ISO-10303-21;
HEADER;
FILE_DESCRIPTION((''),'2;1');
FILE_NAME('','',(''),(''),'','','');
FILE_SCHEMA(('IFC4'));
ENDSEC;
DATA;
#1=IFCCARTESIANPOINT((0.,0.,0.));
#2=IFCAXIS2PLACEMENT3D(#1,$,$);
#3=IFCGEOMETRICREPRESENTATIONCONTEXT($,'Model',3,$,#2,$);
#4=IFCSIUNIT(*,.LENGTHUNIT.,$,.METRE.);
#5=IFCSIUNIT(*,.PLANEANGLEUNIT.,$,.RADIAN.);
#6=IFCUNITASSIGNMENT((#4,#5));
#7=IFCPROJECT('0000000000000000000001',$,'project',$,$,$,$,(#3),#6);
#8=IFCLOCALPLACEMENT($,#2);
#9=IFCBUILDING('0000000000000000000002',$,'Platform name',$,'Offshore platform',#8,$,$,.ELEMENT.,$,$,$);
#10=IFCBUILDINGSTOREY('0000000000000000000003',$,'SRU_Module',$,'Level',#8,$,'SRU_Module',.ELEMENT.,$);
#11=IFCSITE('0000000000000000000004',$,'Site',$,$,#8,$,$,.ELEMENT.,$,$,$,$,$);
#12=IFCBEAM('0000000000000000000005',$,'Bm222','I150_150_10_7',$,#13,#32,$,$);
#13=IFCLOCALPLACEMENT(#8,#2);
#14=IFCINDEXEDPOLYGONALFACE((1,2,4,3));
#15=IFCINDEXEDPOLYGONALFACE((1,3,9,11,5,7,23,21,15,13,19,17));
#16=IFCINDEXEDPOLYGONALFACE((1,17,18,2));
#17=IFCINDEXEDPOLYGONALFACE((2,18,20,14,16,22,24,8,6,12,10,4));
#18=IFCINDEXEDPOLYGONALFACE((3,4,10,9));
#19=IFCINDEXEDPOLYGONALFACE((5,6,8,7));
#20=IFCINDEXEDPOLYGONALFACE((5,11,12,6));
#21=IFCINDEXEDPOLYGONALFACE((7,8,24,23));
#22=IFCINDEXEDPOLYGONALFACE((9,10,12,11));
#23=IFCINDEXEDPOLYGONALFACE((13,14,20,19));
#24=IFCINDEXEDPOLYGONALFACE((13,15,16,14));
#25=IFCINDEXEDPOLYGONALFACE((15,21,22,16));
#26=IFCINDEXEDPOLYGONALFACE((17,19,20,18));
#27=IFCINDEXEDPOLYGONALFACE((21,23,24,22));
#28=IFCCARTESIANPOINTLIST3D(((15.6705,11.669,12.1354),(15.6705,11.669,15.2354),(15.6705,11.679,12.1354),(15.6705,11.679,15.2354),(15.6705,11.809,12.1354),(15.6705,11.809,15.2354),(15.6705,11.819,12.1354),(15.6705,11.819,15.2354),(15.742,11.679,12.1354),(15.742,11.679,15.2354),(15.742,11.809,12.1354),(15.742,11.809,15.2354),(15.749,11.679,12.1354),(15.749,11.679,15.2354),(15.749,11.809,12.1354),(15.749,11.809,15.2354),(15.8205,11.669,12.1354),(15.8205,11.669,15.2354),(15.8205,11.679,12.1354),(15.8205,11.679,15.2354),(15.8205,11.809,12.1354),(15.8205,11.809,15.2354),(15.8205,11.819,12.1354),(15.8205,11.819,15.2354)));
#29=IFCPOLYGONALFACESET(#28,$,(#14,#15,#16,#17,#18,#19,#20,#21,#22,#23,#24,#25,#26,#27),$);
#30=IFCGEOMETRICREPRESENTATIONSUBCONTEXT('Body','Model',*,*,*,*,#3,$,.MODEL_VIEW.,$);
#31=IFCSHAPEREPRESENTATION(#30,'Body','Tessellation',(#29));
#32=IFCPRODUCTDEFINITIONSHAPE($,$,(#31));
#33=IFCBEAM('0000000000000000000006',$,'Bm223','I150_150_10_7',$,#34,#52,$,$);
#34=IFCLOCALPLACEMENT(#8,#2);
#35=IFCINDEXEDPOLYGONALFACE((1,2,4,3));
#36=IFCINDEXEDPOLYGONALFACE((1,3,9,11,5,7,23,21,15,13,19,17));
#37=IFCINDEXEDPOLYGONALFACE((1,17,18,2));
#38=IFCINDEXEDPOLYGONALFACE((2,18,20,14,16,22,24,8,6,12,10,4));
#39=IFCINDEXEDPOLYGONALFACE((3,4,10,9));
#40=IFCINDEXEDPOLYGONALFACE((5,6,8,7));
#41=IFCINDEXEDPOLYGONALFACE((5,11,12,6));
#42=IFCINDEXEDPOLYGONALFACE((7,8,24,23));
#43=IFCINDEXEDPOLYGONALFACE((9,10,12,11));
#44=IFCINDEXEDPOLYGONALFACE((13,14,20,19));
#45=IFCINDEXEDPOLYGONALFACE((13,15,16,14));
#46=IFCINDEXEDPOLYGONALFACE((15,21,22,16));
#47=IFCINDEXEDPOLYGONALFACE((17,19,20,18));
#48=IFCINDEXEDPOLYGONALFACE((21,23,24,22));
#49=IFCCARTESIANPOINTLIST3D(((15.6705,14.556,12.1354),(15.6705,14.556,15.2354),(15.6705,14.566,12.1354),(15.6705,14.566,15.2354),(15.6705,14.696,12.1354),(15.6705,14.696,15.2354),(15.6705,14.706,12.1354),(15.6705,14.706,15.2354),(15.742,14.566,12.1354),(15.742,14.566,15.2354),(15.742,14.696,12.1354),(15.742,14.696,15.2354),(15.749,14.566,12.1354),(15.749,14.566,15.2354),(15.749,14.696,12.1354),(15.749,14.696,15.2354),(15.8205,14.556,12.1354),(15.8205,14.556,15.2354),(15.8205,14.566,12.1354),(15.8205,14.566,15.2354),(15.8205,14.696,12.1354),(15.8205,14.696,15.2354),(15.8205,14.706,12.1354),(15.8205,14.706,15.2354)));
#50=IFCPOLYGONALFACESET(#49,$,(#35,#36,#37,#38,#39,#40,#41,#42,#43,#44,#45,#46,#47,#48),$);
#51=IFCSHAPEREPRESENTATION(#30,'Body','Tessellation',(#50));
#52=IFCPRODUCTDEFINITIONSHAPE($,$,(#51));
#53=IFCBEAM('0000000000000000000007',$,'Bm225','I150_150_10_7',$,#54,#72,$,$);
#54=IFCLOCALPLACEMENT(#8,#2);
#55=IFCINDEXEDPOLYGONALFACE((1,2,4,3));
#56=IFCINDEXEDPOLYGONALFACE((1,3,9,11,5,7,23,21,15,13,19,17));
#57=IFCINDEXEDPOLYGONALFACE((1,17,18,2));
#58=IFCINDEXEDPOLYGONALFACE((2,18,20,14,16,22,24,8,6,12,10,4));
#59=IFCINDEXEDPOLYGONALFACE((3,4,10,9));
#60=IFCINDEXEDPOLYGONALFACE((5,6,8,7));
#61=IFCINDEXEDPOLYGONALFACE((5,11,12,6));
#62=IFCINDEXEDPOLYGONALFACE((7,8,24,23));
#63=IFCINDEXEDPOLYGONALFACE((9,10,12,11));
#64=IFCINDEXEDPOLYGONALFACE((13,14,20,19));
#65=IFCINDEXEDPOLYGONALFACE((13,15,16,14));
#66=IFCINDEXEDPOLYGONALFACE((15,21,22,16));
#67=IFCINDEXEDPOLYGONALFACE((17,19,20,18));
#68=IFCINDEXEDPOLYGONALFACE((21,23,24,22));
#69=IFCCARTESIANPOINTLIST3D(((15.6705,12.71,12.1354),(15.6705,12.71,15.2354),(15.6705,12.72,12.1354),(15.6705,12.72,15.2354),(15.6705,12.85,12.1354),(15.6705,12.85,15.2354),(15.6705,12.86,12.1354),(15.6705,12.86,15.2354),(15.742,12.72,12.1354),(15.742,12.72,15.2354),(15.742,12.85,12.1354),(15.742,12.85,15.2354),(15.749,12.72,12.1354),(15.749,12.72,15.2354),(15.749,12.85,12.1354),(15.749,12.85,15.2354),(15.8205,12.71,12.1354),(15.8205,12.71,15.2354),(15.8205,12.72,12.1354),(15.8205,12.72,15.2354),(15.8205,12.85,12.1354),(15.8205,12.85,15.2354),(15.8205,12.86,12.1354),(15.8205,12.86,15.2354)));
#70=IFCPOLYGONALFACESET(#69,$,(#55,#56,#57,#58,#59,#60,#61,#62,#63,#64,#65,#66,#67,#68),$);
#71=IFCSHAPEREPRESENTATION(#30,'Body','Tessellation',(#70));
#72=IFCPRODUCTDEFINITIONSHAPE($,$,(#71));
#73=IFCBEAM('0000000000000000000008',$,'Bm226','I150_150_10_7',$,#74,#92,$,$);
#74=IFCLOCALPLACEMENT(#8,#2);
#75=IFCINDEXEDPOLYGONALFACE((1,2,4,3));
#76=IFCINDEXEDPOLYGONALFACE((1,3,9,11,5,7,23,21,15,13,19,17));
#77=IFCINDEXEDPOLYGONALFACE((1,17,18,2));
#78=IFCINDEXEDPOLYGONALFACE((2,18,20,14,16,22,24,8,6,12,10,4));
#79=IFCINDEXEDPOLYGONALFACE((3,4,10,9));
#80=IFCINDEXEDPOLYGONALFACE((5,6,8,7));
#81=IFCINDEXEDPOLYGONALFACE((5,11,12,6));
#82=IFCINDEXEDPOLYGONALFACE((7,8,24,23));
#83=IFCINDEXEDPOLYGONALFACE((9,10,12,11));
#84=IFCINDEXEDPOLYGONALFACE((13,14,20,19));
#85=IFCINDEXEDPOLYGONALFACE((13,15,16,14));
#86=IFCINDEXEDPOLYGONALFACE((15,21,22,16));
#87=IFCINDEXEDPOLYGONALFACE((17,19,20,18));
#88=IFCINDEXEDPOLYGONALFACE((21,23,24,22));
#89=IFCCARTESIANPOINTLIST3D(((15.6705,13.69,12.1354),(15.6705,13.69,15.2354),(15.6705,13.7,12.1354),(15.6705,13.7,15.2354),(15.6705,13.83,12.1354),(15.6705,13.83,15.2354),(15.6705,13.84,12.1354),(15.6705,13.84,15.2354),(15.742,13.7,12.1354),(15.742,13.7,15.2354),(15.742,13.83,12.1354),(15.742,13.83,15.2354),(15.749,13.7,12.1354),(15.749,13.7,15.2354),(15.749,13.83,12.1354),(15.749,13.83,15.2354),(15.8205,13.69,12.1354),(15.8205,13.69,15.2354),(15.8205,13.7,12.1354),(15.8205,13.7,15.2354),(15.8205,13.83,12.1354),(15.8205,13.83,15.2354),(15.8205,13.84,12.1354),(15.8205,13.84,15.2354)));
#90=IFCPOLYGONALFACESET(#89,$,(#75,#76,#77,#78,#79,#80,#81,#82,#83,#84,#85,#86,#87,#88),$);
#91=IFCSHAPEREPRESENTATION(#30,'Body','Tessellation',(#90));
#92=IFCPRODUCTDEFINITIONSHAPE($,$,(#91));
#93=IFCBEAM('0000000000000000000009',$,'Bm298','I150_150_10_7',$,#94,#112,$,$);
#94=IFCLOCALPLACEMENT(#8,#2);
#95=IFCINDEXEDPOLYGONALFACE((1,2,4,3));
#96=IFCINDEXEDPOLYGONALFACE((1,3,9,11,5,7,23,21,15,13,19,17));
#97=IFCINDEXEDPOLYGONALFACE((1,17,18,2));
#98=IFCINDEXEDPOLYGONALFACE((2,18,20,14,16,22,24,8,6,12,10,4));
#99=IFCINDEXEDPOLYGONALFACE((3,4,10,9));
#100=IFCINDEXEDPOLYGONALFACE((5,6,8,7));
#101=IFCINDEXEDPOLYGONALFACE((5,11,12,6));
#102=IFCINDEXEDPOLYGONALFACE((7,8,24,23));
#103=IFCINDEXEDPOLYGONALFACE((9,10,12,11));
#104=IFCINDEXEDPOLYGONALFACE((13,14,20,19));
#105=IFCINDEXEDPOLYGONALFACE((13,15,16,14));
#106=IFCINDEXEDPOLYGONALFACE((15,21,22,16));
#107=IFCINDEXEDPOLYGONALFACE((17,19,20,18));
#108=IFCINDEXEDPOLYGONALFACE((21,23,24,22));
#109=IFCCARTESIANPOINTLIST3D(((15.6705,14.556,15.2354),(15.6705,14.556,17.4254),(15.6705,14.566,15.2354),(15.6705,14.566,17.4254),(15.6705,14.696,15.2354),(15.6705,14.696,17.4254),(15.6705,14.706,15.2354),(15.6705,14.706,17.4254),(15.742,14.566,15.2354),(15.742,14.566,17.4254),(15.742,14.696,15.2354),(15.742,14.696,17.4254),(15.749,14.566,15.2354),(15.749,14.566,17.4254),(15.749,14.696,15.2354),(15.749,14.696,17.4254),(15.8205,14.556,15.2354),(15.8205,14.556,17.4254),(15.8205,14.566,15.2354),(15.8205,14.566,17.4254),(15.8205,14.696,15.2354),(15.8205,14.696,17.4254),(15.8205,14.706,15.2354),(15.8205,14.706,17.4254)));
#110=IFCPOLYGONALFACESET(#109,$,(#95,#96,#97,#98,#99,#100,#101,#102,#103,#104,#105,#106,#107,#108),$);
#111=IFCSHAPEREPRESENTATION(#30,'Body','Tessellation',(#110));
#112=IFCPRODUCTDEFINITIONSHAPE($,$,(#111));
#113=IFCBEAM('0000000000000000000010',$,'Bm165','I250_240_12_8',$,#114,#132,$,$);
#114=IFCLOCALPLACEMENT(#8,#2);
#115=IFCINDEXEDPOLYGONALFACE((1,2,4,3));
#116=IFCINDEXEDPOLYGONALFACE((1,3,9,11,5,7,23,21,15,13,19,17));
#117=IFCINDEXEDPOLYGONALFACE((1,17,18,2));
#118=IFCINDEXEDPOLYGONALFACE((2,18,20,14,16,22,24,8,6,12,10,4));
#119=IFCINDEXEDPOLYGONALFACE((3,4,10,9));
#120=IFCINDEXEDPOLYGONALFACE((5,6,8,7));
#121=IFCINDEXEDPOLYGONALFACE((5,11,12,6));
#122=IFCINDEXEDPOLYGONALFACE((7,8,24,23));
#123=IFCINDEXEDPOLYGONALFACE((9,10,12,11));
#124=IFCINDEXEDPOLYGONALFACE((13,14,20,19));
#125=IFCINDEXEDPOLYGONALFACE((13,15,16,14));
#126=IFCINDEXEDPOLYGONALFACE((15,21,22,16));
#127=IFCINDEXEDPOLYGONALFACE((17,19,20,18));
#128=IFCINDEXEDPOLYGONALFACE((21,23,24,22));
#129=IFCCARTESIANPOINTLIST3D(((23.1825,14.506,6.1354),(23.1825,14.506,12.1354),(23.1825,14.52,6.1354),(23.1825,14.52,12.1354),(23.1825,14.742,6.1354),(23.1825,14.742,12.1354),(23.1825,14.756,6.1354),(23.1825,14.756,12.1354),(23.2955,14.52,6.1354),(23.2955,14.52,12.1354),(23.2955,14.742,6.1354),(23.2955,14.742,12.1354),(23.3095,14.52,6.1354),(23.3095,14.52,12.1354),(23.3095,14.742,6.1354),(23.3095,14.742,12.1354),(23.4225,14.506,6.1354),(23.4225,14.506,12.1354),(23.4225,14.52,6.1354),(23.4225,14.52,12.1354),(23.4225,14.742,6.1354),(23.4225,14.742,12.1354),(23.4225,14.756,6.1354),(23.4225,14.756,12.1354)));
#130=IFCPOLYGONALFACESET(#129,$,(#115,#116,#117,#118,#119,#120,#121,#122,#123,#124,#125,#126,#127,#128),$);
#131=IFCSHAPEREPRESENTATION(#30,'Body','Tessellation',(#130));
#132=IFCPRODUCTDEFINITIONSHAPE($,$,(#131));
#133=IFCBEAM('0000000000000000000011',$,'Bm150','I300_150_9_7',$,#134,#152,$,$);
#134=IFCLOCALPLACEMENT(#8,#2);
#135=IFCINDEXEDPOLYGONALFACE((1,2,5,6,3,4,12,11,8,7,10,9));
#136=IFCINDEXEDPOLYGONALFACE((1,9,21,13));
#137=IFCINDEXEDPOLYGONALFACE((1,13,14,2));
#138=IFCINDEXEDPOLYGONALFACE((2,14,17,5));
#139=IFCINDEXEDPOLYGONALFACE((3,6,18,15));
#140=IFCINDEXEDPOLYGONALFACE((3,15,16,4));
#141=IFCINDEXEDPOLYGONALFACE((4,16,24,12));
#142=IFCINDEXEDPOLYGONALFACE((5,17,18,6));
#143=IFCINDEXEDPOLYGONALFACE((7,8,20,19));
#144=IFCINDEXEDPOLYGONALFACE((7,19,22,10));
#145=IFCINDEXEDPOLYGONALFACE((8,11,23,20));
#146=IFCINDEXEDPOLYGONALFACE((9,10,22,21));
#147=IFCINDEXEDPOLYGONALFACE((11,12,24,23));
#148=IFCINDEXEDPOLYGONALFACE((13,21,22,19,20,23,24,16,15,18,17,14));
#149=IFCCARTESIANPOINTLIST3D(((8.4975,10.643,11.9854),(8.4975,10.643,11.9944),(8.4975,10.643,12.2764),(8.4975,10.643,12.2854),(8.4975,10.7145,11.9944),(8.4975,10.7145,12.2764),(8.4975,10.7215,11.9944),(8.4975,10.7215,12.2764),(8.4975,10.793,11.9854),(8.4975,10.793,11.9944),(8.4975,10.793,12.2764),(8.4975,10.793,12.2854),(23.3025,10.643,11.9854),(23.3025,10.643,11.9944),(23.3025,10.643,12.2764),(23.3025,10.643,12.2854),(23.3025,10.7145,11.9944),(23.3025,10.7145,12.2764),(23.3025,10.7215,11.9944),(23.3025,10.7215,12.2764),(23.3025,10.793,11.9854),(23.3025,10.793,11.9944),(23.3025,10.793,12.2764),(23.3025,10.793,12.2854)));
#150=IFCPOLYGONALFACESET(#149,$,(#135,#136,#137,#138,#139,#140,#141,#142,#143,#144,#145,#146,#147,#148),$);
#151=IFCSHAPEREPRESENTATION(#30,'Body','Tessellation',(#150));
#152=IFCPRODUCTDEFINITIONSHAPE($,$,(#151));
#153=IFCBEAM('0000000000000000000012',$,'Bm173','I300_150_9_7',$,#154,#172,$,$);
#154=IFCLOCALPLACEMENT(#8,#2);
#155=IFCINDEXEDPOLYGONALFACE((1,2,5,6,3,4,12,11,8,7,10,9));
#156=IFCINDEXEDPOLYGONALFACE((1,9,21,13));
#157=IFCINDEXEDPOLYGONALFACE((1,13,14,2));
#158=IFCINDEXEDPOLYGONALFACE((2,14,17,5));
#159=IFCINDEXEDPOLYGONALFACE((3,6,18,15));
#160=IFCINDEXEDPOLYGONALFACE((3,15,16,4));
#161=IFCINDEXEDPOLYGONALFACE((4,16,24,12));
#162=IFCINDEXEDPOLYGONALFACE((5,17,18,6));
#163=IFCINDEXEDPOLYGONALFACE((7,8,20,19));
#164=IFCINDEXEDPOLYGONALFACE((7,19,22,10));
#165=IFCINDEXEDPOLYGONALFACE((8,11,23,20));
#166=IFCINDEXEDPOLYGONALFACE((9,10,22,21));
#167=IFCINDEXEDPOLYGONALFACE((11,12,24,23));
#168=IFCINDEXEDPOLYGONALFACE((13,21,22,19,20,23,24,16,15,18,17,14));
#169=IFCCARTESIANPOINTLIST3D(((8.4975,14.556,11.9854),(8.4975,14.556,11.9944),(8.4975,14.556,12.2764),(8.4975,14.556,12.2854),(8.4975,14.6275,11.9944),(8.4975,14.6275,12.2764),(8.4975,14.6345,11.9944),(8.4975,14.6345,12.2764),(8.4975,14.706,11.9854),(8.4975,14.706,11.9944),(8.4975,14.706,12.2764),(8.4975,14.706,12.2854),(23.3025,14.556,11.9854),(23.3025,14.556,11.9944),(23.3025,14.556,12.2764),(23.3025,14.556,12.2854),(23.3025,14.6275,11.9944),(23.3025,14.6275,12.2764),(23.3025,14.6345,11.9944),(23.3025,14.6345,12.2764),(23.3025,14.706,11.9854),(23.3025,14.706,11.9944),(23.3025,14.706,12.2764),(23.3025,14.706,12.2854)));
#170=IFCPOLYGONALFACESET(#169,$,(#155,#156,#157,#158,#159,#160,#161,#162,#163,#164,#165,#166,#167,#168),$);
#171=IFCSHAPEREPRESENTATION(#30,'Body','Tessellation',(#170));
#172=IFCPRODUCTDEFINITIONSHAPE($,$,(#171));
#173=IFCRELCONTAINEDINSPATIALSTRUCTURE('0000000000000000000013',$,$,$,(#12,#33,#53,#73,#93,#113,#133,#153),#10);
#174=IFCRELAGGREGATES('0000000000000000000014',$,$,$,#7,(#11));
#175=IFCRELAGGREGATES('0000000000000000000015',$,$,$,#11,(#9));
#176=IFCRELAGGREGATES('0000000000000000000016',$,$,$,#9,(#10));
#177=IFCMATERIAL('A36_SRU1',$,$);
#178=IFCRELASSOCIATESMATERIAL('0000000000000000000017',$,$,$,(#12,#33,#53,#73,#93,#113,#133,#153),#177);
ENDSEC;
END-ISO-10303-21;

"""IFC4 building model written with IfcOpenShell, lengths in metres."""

from ifc_helpers import new_model, si_unit, frame, origin, origin_with_axes, origin_2d, place, context, subcontext, project, spatial, i_section, extrude, source, transform, mapped, material, element, save


model = new_model("IFC4")

# Units and contexts
model_context = context("Model", 3, world=origin())
body_context = subcontext(model_context, "Body", "Model", "MODEL_VIEW")
ifc_project = project(units=[si_unit("LENGTHUNIT", "METRE"), si_unit("PLANEANGLEUNIT", "RADIAN")], contexts=[model_context])

# Site, building, storey
placement_1 = place(None, origin())
site = spatial("IfcSite", under=ifc_project, at=placement_1, Name="Site", CompositionType="ELEMENT")
building = spatial("IfcBuilding", under=site, at=placement_1, Name="Platform name", ObjectType="Offshore platform", CompositionType="ELEMENT")
storey = spatial("IfcBuildingStorey", under=building, at=placement_1, Name="SRU_Module", ObjectType="Level", LongName="SRU_Module", CompositionType="ELEMENT")

# Beams
ifc_material = material(Name="A36_SRU1")
shared_shape_1 = source(origin(), body_context, "Body", "SweptSolid", [
    extrude(i_section(OverallWidth=0.15, OverallDepth=0.15, WebThickness=0.007, FlangeThickness=0.01, FilletRadius=0.0, at=origin_2d()), origin_with_axes(), (0.0, 0.0, 1.0), 3.1),
])
placement_2 = place(None, origin())
placement_3 = place(placement_2, origin())
placement_4 = place(placement_3, origin())
beam_1_placement = place(placement_4, frame((15.7455, 11.744, 12.1354)))
element("IfcBeam", 1, at=beam_1_placement, inside=storey, material=ifc_material, Name="Bm222", Description="I150_150_10_7", context=body_context, shape_type="MappedRepresentation", body=[
    mapped(shared_shape_1, transform((0.0, 0.0, 0.0), scale=1.0)),
])
shared_shape_2 = source(origin(), body_context, "Body", "SweptSolid", [
    extrude(i_section(OverallWidth=0.15, OverallDepth=0.15, WebThickness=0.007, FlangeThickness=0.01, FilletRadius=0.0, at=origin_2d()), origin_with_axes(), (0.0, 0.0, 1.0), 3.1),
])
placement_5 = place(None, origin())
placement_6 = place(placement_5, origin())
placement_7 = place(placement_6, origin())
beam_2_placement = place(placement_7, frame((15.7455, 14.631, 12.1354)))
element("IfcBeam", 2, at=beam_2_placement, inside=storey, material=ifc_material, Name="Bm223", Description="I150_150_10_7", context=body_context, shape_type="MappedRepresentation", body=[
    mapped(shared_shape_2, transform((0.0, 0.0, 0.0), scale=1.0)),
])
shared_shape_3 = source(origin(), body_context, "Body", "SweptSolid", [
    extrude(i_section(OverallWidth=0.15, OverallDepth=0.15, WebThickness=0.007, FlangeThickness=0.01, FilletRadius=0.0, at=origin_2d()), origin_with_axes(), (0.0, 0.0, 1.0), 3.1),
])
placement_8 = place(None, origin())
placement_9 = place(placement_8, origin())
placement_10 = place(placement_9, origin())
beam_3_placement = place(placement_10, frame((15.7455, 12.785, 12.1354)))
element("IfcBeam", 3, at=beam_3_placement, inside=storey, material=ifc_material, Name="Bm225", Description="I150_150_10_7", context=body_context, shape_type="MappedRepresentation", body=[
    mapped(shared_shape_3, transform((0.0, 0.0, 0.0), scale=1.0)),
])
shared_shape_4 = source(origin(), body_context, "Body", "SweptSolid", [
    extrude(i_section(OverallWidth=0.15, OverallDepth=0.15, WebThickness=0.007, FlangeThickness=0.01, FilletRadius=0.0, at=origin_2d()), origin_with_axes(), (0.0, 0.0, 1.0), 3.1),
])
placement_11 = place(None, origin())
placement_12 = place(placement_11, origin())
placement_13 = place(placement_12, origin())
beam_4_placement = place(placement_13, frame((15.7455, 13.765, 12.1354)))
element("IfcBeam", 4, at=beam_4_placement, inside=storey, material=ifc_material, Name="Bm226", Description="I150_150_10_7", context=body_context, shape_type="MappedRepresentation", body=[
    mapped(shared_shape_4, transform((0.0, 0.0, 0.0), scale=1.0)),
])
shared_shape_5 = source(origin(), body_context, "Body", "SweptSolid", [
    extrude(i_section(OverallWidth=0.15, OverallDepth=0.15, WebThickness=0.007, FlangeThickness=0.01, FilletRadius=0.0, at=origin_2d()), origin_with_axes(), (0.0, 0.0, 1.0), 2.19),
])
placement_14 = place(None, origin())
placement_15 = place(placement_14, origin())
placement_16 = place(placement_15, origin())
beam_5_placement = place(placement_16, frame((15.7455, 14.631, 15.2354)))
element("IfcBeam", 5, at=beam_5_placement, inside=storey, material=ifc_material, Name="Bm298", Description="I150_150_10_7", context=body_context, shape_type="MappedRepresentation", body=[
    mapped(shared_shape_5, transform((0.0, 0.0, 0.0), scale=1.0)),
])
shared_shape_6 = source(origin(), body_context, "Body", "SweptSolid", [
    extrude(i_section(OverallWidth=0.24, OverallDepth=0.25, WebThickness=0.014, FlangeThickness=0.014, FilletRadius=0.0, at=origin_2d()), origin_with_axes(), (0.0, 0.0, 1.0), 6.0),
])
placement_17 = place(None, origin())
placement_18 = place(placement_17, origin())
placement_19 = place(placement_18, origin())
beam_6_placement = place(placement_19, frame((23.3025, 14.631, 6.1354)))
element("IfcBeam", 6, at=beam_6_placement, inside=storey, material=ifc_material, Name="Bm165", Description="I250_240_12_8", context=body_context, shape_type="MappedRepresentation", body=[
    mapped(shared_shape_6, transform((0.0, 0.0, 0.0), scale=1.0)),
])
shared_shape_7 = source(origin(), body_context, "Body", "SweptSolid", [
    extrude(i_section(OverallWidth=0.15, OverallDepth=0.3, WebThickness=0.007, FlangeThickness=0.009, FilletRadius=0.0, at=origin_2d()), frame((0.0, 0.0, 0.0), z_axis=(-1.0, 0.0, 0.0), x_axis=(0.0, -1.0, 0.0)), (0.0, 0.0, 1.0), 14.805),
])
placement_20 = place(None, origin())
placement_21 = place(placement_20, origin())
placement_22 = place(placement_21, origin())
beam_7_placement = place(placement_22, frame((23.3025, 10.718, 12.1354)))
element("IfcBeam", 7, at=beam_7_placement, inside=storey, material=ifc_material, Name="Bm150", Description="I300_150_9_7", context=body_context, shape_type="MappedRepresentation", body=[
    mapped(shared_shape_7, transform((0.0, 0.0, 0.0), scale=1.0)),
])
shared_shape_8 = source(origin(), body_context, "Body", "SweptSolid", [
    extrude(i_section(OverallWidth=0.15, OverallDepth=0.3, WebThickness=0.007, FlangeThickness=0.009, FilletRadius=0.0, at=origin_2d()), frame((0.0, 0.0, 0.0), z_axis=(-1.0, 0.0, 0.0), x_axis=(0.0, -1.0, 0.0)), (0.0, 0.0, 1.0), 14.805),
])
placement_23 = place(None, origin())
placement_24 = place(placement_23, origin())
placement_25 = place(placement_24, origin())
beam_8_placement = place(placement_25, frame((23.3025, 14.631, 12.1354)))
element("IfcBeam", 8, at=beam_8_placement, inside=storey, material=ifc_material, Name="Bm173", Description="I300_150_9_7", context=body_context, shape_type="MappedRepresentation", body=[
    mapped(shared_shape_8, transform((0.0, 0.0, 0.0), scale=1.0)),
])

save(model, "model.ifc")
